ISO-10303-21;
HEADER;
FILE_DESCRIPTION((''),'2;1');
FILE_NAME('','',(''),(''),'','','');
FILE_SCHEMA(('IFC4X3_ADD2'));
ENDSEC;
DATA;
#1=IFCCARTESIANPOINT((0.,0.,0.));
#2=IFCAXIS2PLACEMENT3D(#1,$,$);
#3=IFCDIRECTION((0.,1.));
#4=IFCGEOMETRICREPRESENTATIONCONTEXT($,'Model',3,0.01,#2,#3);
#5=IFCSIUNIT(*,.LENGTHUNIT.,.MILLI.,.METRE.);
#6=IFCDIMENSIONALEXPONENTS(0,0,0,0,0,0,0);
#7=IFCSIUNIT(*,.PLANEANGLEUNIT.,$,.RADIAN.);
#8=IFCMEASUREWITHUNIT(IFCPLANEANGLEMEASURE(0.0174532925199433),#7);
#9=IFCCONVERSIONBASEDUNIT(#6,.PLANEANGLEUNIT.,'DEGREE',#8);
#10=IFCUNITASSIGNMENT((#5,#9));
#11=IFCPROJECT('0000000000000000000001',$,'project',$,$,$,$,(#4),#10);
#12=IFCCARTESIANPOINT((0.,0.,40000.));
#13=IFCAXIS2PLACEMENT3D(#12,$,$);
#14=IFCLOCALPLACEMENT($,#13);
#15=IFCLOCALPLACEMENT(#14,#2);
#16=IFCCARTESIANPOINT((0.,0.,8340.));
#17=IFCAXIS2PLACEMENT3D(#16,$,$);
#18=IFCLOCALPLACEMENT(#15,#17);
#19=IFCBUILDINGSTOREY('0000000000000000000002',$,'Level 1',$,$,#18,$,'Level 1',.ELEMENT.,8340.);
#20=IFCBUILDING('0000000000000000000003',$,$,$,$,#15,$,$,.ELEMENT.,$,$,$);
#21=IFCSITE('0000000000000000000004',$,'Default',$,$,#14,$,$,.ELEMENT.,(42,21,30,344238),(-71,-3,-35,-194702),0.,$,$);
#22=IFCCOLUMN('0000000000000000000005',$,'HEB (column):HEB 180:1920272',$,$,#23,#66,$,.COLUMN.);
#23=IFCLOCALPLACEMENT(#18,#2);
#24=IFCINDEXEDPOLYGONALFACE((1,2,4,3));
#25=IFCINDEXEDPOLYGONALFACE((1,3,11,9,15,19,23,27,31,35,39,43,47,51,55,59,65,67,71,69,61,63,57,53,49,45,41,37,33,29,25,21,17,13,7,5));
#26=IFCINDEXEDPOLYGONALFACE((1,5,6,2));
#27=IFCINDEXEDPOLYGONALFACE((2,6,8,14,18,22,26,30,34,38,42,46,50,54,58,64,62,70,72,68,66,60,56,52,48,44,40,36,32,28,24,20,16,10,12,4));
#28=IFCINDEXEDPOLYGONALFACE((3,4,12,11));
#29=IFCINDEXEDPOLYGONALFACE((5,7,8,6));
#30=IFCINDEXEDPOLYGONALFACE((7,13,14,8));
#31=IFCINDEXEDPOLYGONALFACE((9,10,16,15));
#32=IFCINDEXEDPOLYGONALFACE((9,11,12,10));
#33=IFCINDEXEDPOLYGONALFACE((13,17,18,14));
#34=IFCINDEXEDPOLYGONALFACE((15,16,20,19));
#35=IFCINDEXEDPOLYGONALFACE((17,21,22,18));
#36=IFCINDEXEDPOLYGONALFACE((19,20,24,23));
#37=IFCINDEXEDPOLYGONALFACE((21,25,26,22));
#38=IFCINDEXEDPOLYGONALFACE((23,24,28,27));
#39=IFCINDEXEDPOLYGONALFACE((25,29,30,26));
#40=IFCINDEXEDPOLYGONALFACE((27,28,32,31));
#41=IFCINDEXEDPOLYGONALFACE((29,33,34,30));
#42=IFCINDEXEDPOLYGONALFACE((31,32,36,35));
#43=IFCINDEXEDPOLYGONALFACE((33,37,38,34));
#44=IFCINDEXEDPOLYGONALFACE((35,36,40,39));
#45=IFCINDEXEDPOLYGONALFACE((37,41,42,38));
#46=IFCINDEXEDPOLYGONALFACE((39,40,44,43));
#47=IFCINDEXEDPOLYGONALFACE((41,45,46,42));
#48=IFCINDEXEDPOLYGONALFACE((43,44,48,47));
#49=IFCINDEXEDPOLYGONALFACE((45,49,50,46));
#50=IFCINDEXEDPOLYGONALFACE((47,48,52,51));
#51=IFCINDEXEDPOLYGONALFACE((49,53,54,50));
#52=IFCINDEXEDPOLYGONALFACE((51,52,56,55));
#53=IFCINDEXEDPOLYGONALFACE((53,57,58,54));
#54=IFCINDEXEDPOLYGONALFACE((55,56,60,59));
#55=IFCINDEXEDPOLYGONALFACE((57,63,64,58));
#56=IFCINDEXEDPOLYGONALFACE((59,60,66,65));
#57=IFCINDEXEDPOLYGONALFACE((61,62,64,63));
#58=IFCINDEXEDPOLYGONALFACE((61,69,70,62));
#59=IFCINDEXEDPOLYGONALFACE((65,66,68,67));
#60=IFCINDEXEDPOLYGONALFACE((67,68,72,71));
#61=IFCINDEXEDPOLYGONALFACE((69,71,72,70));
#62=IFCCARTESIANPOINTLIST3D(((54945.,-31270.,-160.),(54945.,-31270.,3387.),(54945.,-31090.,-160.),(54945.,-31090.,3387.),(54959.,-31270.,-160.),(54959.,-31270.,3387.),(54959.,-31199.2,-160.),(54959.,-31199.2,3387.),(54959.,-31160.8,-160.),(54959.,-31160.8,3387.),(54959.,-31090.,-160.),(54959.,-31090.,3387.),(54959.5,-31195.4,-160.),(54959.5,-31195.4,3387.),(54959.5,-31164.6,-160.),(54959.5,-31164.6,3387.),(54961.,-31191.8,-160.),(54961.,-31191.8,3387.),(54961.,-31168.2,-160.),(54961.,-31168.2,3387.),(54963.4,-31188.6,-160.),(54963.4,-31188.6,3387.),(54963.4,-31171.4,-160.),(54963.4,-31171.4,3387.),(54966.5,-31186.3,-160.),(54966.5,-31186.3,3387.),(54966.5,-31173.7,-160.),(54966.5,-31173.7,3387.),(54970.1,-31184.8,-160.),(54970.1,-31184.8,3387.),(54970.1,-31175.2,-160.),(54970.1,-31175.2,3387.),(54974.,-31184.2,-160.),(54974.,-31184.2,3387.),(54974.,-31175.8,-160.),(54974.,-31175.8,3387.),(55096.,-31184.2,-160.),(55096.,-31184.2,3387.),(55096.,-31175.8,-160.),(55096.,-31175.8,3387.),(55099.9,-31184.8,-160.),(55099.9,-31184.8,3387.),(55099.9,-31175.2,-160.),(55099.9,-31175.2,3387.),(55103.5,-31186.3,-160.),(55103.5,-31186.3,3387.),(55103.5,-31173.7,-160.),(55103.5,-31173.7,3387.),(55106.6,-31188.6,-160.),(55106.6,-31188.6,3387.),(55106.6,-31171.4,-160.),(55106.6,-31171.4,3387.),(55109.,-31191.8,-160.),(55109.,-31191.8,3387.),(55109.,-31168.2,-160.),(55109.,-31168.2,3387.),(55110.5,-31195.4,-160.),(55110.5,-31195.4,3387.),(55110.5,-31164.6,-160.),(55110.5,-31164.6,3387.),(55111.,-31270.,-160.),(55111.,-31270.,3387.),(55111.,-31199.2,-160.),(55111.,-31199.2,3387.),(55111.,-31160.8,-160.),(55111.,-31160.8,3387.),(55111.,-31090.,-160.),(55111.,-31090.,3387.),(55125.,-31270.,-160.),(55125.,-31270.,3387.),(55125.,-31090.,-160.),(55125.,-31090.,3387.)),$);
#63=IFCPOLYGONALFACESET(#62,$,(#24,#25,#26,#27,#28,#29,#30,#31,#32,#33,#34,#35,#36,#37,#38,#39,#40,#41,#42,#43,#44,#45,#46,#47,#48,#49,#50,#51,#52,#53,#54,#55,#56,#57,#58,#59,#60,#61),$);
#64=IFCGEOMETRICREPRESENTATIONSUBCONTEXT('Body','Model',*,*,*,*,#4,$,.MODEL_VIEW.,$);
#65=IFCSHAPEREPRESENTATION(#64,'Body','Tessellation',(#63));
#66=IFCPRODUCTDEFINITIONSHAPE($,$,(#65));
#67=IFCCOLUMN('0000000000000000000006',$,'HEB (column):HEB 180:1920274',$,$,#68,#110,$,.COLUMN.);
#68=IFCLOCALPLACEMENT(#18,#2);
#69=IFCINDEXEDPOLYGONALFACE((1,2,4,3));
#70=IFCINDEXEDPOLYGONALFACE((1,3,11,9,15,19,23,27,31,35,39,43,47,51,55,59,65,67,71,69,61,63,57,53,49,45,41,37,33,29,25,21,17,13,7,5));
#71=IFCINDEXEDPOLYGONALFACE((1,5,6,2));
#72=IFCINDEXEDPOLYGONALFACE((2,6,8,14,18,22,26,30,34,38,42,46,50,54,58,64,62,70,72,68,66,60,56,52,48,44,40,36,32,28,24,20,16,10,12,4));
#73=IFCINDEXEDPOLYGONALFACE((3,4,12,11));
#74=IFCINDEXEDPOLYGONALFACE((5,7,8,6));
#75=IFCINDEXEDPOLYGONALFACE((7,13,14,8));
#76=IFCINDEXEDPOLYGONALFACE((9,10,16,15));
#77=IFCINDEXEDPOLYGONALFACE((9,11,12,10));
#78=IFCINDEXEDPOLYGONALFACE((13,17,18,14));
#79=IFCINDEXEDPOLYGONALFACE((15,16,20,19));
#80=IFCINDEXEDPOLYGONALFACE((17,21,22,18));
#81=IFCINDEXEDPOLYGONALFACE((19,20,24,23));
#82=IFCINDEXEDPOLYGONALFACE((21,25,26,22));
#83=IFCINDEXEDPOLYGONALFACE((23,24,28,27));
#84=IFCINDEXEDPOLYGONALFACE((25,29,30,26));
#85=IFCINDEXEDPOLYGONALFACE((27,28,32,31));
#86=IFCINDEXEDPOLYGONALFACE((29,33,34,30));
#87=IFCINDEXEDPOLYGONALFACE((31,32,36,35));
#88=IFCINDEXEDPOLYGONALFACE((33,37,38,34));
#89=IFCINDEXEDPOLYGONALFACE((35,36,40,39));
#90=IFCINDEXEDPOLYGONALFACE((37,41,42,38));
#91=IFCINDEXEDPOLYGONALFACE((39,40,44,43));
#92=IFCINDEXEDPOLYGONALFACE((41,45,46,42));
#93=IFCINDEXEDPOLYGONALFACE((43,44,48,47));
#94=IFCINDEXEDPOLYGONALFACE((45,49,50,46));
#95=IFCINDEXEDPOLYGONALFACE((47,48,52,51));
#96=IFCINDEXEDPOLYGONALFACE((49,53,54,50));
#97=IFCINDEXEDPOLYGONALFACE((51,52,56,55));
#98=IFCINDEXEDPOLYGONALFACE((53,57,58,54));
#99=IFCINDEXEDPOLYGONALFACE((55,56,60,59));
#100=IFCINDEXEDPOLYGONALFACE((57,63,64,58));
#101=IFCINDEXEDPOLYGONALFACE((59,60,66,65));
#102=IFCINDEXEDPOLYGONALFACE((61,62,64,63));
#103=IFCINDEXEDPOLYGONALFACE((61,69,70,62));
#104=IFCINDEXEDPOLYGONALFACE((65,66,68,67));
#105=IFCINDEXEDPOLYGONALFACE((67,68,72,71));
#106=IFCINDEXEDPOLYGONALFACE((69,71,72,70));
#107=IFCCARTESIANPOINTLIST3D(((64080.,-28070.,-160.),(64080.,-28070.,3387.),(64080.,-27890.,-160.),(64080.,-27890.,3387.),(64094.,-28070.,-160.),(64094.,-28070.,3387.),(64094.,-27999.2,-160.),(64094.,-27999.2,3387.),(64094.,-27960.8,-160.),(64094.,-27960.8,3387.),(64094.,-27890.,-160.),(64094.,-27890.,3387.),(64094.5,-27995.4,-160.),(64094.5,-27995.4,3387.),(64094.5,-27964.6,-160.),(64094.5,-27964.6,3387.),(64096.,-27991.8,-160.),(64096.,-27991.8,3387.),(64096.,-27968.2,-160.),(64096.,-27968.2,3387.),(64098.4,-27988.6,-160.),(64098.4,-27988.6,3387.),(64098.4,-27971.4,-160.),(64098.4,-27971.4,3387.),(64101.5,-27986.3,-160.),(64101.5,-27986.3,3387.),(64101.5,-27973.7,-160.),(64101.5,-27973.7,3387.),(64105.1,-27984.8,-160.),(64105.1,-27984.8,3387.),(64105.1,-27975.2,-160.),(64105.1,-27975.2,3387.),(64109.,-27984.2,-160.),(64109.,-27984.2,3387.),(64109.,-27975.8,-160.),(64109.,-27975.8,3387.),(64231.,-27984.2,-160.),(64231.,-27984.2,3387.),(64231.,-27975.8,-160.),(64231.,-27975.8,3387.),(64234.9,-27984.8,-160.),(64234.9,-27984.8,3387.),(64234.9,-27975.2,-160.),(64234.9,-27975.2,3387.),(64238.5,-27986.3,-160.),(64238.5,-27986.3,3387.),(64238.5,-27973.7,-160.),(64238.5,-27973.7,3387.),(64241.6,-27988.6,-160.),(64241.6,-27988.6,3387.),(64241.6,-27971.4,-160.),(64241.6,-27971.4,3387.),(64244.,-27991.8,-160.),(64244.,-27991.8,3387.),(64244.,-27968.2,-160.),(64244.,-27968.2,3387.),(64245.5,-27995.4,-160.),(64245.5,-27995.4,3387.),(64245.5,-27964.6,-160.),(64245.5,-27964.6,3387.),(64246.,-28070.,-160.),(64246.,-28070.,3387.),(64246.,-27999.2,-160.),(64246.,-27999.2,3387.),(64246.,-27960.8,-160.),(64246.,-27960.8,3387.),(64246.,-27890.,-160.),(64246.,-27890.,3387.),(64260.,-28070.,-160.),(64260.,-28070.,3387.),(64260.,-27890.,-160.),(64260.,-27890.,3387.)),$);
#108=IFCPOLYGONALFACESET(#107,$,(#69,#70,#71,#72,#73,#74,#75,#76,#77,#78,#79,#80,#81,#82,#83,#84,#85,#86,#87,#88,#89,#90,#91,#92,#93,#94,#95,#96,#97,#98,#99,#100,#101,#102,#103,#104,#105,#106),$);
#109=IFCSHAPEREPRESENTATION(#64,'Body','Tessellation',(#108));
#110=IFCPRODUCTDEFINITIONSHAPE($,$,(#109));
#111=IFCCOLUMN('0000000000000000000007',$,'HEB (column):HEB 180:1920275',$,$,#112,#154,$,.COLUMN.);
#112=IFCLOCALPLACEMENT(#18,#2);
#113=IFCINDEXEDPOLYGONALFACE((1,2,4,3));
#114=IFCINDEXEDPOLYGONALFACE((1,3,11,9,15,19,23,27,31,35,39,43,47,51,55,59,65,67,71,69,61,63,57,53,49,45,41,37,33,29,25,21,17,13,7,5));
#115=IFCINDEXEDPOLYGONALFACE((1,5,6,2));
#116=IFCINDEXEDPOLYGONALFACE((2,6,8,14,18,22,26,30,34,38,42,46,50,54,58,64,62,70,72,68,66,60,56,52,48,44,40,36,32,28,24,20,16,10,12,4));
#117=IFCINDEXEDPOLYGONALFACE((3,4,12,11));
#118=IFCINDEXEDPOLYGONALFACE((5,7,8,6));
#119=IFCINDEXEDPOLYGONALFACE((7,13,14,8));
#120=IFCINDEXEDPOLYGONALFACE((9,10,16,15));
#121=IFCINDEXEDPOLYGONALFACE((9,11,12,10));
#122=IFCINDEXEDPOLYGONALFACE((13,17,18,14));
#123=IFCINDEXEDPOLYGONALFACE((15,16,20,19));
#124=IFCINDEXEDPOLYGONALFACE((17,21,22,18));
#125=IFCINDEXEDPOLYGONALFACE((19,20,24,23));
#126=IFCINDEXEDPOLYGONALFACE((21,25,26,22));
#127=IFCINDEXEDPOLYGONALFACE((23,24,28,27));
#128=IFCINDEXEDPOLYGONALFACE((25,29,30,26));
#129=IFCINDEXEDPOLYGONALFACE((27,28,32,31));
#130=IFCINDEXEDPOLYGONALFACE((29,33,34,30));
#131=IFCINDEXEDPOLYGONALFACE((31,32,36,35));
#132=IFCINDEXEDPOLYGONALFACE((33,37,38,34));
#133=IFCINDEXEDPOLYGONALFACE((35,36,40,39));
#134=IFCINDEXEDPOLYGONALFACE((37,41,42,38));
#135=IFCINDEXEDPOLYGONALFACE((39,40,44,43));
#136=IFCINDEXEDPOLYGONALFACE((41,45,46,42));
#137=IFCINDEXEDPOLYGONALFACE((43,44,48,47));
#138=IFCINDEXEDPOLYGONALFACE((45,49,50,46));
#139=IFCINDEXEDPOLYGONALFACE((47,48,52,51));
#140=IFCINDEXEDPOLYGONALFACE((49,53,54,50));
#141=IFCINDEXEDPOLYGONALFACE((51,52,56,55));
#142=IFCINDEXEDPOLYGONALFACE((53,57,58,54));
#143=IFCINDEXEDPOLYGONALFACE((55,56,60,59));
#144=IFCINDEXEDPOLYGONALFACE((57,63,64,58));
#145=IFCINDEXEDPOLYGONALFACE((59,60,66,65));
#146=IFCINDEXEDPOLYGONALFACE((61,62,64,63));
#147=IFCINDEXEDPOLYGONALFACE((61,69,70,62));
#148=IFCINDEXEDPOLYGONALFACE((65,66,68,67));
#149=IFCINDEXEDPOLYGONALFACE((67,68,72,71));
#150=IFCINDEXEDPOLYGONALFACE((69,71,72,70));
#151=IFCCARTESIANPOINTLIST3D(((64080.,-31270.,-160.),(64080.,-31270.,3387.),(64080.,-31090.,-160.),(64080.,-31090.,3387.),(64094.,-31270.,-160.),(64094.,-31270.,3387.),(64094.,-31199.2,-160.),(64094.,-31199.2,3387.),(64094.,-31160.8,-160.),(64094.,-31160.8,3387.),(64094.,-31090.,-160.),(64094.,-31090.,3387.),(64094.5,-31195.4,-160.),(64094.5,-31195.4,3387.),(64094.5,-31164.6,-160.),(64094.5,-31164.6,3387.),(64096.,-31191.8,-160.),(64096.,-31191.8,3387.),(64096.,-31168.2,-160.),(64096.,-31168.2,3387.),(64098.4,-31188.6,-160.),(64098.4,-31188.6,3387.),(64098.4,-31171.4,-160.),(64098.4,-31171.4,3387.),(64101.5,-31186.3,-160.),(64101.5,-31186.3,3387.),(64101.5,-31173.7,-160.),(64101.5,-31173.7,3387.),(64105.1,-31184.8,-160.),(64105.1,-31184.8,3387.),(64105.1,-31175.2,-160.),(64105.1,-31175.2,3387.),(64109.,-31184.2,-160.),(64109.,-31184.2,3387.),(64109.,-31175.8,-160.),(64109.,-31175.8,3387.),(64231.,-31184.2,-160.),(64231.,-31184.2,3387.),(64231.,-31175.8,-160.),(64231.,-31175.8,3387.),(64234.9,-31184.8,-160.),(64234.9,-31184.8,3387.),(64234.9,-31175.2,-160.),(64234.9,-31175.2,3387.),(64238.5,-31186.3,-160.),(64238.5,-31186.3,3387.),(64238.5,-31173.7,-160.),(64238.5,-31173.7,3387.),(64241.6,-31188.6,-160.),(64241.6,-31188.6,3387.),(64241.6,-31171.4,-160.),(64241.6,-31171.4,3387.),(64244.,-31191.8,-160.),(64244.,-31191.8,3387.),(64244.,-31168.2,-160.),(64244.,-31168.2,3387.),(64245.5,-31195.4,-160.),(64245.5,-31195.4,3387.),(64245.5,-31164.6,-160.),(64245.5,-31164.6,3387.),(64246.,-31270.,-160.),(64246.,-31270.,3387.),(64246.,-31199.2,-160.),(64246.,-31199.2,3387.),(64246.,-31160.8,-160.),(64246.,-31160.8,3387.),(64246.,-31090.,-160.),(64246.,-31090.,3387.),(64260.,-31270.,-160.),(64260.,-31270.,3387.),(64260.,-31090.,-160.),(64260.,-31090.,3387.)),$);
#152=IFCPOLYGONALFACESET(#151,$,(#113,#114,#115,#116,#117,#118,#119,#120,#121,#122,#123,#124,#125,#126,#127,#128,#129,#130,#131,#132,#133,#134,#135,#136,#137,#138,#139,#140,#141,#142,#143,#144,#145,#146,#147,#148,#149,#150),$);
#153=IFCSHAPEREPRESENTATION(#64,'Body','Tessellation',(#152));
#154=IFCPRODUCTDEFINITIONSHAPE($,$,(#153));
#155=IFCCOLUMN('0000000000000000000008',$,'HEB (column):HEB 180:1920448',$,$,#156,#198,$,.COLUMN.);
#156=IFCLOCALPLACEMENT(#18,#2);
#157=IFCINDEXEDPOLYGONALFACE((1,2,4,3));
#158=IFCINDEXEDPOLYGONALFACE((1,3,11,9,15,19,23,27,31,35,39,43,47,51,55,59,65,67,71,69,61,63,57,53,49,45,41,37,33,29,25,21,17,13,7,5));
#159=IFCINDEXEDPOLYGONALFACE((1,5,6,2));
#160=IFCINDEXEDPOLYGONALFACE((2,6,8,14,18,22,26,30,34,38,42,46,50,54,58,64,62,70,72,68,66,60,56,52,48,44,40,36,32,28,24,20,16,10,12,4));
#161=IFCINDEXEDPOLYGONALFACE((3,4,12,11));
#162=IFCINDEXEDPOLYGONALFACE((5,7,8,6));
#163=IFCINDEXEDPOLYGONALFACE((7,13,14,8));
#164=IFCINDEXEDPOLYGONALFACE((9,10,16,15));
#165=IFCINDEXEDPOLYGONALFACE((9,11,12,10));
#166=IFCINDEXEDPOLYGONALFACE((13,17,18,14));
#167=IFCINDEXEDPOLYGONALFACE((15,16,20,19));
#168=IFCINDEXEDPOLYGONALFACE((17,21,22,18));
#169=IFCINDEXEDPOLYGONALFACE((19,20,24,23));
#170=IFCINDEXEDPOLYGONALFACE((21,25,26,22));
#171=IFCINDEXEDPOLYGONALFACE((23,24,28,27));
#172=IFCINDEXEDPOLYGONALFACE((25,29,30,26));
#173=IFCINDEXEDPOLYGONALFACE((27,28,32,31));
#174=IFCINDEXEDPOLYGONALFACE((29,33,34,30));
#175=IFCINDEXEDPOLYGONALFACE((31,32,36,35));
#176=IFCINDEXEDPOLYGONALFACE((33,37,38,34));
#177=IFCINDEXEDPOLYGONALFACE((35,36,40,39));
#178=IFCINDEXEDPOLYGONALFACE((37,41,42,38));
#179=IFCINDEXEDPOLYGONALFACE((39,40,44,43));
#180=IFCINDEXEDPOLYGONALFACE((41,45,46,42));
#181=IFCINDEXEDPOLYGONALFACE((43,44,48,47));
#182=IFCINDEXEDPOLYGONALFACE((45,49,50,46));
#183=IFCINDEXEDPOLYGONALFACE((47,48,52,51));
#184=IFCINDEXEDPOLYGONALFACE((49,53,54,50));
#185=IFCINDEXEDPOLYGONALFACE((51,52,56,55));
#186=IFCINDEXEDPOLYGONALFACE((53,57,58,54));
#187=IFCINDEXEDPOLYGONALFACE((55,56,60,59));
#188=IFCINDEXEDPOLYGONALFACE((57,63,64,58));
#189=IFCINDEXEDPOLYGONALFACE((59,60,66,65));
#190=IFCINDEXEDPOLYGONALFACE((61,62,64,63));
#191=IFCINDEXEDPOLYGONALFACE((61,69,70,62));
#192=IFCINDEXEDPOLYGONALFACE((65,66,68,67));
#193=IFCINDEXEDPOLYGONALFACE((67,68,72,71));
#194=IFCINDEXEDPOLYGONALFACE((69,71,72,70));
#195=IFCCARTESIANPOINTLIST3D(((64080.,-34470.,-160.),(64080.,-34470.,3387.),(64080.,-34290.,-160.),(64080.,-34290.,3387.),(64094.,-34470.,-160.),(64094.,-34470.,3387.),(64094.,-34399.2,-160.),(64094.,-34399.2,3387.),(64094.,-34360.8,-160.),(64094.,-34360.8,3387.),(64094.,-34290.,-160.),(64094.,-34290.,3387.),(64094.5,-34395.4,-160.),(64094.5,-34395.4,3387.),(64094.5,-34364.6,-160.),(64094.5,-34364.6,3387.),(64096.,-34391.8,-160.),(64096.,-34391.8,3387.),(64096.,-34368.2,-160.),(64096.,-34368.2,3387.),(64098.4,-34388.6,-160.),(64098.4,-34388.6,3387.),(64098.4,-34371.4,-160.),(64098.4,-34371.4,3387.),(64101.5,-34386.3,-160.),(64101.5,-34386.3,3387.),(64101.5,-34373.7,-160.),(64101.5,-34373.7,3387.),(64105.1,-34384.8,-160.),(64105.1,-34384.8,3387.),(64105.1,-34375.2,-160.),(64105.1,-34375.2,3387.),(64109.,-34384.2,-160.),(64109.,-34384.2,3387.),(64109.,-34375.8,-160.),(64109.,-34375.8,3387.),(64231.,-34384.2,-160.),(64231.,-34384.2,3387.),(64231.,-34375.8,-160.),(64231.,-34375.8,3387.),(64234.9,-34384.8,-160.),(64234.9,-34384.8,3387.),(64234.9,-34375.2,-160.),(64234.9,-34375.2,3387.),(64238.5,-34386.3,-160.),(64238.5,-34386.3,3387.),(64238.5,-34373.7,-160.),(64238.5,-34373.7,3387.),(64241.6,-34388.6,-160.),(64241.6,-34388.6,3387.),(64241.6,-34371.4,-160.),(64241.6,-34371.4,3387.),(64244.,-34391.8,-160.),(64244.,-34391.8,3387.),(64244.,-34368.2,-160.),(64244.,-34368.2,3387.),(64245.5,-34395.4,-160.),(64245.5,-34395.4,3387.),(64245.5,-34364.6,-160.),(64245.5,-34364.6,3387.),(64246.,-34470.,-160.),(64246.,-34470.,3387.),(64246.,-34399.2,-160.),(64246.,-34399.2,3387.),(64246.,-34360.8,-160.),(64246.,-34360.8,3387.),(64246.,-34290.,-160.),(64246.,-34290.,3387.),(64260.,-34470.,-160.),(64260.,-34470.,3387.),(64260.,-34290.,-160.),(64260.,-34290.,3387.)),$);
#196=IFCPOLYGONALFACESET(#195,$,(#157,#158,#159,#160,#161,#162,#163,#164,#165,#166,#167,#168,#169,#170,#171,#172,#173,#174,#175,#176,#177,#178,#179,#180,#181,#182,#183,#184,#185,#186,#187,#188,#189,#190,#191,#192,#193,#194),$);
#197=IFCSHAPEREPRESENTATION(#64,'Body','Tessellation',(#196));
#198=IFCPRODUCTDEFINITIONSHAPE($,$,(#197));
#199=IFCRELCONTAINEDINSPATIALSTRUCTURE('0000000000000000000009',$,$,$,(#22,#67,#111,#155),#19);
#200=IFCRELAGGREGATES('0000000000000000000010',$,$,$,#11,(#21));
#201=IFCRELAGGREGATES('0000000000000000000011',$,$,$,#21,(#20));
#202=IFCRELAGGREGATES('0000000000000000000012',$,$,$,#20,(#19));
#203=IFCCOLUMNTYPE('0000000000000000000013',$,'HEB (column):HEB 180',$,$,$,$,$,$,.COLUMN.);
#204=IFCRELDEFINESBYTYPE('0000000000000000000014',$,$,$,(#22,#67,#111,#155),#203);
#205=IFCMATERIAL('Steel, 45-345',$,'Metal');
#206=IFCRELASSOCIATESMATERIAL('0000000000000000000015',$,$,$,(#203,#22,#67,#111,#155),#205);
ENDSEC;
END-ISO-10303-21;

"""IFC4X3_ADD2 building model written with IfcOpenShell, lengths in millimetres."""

from ifc_helpers import new_model, entity, si_unit, converted_unit, direction, frame, origin, origin_2d_with_axis, place, context, subcontext, project, spatial, i_section, extrude, source, transform, mapped, material, material_profile, profile_set, profile_usage, type_object, type_shapes, element, save


model = new_model("IFC4X3_ADD2")

# Units and contexts
model_context = context("Model", 3, precision=0.01, world=origin(), true_north=direction((0.0, 1.0)))
body_context = subcontext(model_context, "Body", "Model", "MODEL_VIEW")
ifc_project = project(units=[si_unit("LENGTHUNIT", "METRE", prefix="MILLI"), converted_unit("PLANEANGLEUNIT", "DEGREE", entity("IfcPlaneAngleMeasure", 0.0174532925199433), si_unit("PLANEANGLEUNIT", "RADIAN"), dimensions=[0, 0, 0, 0, 0, 0, 0])], contexts=[model_context])

# Site, building, storey
site_placement = place(None, frame((0.0, 0.0, 40000.0)))
site = spatial("IfcSite", under=ifc_project, at=site_placement, Name="Default", CompositionType="ELEMENT", RefLatitude=(42, 21, 30, 344238), RefLongitude=(-71, -3, -35, -194702), RefElevation=0.0)
building_placement = place(site_placement, origin())
building = spatial("IfcBuilding", under=site, at=building_placement, CompositionType="ELEMENT")
storey_placement = place(building_placement, frame((0.0, 0.0, 8340.0)))
storey = spatial("IfcBuildingStorey", under=building, at=storey_placement, Name="Level 1", LongName="Level 1", CompositionType="ELEMENT", Elevation=8340.0)

# Columns
ifc_material_1 = material(Name="Steel, 45-345", Category="Metal")
ifc_material_profile_1 = material_profile(ifc_material_1, i_section(OverallWidth=180.0, OverallDepth=180.0, WebThickness=8.5, FlangeThickness=14.0, FilletRadius=15.0, at=origin_2d_with_axis()), Name="HEB 180")
ifc_profile_set_1 = profile_set([ifc_material_profile_1], Name="HEB 180")
ifc_profile_usage_1 = profile_usage(ifc_profile_set_1)
column_type_1 = type_object("IfcColumnType", Name="HEB (column):HEB 180", PredefinedType="COLUMN", material=ifc_profile_set_1)
shared_shape_1 = source(origin(), body_context, "Body", "SweptSolid", [
    extrude(i_section(OverallWidth=180.0, OverallDepth=180.0, WebThickness=8.5, FlangeThickness=14.0, FilletRadius=15.0, at=origin_2d_with_axis()), frame((0.0, 0.0, 8180.0), z_axis=(0.0, 0.0, 1.0), x_axis=(-1.0, 0.0, 0.0)), (0.0, 0.0, 1.0), 3547.0),
])
type_shapes(column_type_1, [shared_shape_1])
for number, where, z_axis, x_axis, name in (
    (1, (55035.0, -31180.0, -8340.0), (0.0, 0.0, 1.0), (0.0, -1.0, 0.0), "HEB (column):HEB 180:1920272"),
    (2, (64170.0, -27980.0, -8340.0), (0.0, 0.0, 1.0), (0.0, -1.0, 0.0), "HEB (column):HEB 180:1920274"),
    (3, (64170.0, -31180.0, -8340.0), (0.0, 0.0, 1.0), (0.0, -1.0, 0.0), "HEB (column):HEB 180:1920275"),
    (4, (64170.0, -34380.0, -8340.0), (0.0, 0.0, 1.0), (0.0, -1.0, 0.0), "HEB (column):HEB 180:1920448"),
):
    element("IfcColumn", number, at=place(storey_placement, frame(where, z_axis=z_axis, x_axis=x_axis)), inside=storey, type_object=column_type_1, material=ifc_profile_usage_1, Name=name, PredefinedType="COLUMN", context=body_context, shape_type="MappedRepresentation", body=[
        mapped(shared_shape_1, transform((0.0, 0.0, 0.0), scale=1.0)),
    ])

save(model, "model.ifc")
